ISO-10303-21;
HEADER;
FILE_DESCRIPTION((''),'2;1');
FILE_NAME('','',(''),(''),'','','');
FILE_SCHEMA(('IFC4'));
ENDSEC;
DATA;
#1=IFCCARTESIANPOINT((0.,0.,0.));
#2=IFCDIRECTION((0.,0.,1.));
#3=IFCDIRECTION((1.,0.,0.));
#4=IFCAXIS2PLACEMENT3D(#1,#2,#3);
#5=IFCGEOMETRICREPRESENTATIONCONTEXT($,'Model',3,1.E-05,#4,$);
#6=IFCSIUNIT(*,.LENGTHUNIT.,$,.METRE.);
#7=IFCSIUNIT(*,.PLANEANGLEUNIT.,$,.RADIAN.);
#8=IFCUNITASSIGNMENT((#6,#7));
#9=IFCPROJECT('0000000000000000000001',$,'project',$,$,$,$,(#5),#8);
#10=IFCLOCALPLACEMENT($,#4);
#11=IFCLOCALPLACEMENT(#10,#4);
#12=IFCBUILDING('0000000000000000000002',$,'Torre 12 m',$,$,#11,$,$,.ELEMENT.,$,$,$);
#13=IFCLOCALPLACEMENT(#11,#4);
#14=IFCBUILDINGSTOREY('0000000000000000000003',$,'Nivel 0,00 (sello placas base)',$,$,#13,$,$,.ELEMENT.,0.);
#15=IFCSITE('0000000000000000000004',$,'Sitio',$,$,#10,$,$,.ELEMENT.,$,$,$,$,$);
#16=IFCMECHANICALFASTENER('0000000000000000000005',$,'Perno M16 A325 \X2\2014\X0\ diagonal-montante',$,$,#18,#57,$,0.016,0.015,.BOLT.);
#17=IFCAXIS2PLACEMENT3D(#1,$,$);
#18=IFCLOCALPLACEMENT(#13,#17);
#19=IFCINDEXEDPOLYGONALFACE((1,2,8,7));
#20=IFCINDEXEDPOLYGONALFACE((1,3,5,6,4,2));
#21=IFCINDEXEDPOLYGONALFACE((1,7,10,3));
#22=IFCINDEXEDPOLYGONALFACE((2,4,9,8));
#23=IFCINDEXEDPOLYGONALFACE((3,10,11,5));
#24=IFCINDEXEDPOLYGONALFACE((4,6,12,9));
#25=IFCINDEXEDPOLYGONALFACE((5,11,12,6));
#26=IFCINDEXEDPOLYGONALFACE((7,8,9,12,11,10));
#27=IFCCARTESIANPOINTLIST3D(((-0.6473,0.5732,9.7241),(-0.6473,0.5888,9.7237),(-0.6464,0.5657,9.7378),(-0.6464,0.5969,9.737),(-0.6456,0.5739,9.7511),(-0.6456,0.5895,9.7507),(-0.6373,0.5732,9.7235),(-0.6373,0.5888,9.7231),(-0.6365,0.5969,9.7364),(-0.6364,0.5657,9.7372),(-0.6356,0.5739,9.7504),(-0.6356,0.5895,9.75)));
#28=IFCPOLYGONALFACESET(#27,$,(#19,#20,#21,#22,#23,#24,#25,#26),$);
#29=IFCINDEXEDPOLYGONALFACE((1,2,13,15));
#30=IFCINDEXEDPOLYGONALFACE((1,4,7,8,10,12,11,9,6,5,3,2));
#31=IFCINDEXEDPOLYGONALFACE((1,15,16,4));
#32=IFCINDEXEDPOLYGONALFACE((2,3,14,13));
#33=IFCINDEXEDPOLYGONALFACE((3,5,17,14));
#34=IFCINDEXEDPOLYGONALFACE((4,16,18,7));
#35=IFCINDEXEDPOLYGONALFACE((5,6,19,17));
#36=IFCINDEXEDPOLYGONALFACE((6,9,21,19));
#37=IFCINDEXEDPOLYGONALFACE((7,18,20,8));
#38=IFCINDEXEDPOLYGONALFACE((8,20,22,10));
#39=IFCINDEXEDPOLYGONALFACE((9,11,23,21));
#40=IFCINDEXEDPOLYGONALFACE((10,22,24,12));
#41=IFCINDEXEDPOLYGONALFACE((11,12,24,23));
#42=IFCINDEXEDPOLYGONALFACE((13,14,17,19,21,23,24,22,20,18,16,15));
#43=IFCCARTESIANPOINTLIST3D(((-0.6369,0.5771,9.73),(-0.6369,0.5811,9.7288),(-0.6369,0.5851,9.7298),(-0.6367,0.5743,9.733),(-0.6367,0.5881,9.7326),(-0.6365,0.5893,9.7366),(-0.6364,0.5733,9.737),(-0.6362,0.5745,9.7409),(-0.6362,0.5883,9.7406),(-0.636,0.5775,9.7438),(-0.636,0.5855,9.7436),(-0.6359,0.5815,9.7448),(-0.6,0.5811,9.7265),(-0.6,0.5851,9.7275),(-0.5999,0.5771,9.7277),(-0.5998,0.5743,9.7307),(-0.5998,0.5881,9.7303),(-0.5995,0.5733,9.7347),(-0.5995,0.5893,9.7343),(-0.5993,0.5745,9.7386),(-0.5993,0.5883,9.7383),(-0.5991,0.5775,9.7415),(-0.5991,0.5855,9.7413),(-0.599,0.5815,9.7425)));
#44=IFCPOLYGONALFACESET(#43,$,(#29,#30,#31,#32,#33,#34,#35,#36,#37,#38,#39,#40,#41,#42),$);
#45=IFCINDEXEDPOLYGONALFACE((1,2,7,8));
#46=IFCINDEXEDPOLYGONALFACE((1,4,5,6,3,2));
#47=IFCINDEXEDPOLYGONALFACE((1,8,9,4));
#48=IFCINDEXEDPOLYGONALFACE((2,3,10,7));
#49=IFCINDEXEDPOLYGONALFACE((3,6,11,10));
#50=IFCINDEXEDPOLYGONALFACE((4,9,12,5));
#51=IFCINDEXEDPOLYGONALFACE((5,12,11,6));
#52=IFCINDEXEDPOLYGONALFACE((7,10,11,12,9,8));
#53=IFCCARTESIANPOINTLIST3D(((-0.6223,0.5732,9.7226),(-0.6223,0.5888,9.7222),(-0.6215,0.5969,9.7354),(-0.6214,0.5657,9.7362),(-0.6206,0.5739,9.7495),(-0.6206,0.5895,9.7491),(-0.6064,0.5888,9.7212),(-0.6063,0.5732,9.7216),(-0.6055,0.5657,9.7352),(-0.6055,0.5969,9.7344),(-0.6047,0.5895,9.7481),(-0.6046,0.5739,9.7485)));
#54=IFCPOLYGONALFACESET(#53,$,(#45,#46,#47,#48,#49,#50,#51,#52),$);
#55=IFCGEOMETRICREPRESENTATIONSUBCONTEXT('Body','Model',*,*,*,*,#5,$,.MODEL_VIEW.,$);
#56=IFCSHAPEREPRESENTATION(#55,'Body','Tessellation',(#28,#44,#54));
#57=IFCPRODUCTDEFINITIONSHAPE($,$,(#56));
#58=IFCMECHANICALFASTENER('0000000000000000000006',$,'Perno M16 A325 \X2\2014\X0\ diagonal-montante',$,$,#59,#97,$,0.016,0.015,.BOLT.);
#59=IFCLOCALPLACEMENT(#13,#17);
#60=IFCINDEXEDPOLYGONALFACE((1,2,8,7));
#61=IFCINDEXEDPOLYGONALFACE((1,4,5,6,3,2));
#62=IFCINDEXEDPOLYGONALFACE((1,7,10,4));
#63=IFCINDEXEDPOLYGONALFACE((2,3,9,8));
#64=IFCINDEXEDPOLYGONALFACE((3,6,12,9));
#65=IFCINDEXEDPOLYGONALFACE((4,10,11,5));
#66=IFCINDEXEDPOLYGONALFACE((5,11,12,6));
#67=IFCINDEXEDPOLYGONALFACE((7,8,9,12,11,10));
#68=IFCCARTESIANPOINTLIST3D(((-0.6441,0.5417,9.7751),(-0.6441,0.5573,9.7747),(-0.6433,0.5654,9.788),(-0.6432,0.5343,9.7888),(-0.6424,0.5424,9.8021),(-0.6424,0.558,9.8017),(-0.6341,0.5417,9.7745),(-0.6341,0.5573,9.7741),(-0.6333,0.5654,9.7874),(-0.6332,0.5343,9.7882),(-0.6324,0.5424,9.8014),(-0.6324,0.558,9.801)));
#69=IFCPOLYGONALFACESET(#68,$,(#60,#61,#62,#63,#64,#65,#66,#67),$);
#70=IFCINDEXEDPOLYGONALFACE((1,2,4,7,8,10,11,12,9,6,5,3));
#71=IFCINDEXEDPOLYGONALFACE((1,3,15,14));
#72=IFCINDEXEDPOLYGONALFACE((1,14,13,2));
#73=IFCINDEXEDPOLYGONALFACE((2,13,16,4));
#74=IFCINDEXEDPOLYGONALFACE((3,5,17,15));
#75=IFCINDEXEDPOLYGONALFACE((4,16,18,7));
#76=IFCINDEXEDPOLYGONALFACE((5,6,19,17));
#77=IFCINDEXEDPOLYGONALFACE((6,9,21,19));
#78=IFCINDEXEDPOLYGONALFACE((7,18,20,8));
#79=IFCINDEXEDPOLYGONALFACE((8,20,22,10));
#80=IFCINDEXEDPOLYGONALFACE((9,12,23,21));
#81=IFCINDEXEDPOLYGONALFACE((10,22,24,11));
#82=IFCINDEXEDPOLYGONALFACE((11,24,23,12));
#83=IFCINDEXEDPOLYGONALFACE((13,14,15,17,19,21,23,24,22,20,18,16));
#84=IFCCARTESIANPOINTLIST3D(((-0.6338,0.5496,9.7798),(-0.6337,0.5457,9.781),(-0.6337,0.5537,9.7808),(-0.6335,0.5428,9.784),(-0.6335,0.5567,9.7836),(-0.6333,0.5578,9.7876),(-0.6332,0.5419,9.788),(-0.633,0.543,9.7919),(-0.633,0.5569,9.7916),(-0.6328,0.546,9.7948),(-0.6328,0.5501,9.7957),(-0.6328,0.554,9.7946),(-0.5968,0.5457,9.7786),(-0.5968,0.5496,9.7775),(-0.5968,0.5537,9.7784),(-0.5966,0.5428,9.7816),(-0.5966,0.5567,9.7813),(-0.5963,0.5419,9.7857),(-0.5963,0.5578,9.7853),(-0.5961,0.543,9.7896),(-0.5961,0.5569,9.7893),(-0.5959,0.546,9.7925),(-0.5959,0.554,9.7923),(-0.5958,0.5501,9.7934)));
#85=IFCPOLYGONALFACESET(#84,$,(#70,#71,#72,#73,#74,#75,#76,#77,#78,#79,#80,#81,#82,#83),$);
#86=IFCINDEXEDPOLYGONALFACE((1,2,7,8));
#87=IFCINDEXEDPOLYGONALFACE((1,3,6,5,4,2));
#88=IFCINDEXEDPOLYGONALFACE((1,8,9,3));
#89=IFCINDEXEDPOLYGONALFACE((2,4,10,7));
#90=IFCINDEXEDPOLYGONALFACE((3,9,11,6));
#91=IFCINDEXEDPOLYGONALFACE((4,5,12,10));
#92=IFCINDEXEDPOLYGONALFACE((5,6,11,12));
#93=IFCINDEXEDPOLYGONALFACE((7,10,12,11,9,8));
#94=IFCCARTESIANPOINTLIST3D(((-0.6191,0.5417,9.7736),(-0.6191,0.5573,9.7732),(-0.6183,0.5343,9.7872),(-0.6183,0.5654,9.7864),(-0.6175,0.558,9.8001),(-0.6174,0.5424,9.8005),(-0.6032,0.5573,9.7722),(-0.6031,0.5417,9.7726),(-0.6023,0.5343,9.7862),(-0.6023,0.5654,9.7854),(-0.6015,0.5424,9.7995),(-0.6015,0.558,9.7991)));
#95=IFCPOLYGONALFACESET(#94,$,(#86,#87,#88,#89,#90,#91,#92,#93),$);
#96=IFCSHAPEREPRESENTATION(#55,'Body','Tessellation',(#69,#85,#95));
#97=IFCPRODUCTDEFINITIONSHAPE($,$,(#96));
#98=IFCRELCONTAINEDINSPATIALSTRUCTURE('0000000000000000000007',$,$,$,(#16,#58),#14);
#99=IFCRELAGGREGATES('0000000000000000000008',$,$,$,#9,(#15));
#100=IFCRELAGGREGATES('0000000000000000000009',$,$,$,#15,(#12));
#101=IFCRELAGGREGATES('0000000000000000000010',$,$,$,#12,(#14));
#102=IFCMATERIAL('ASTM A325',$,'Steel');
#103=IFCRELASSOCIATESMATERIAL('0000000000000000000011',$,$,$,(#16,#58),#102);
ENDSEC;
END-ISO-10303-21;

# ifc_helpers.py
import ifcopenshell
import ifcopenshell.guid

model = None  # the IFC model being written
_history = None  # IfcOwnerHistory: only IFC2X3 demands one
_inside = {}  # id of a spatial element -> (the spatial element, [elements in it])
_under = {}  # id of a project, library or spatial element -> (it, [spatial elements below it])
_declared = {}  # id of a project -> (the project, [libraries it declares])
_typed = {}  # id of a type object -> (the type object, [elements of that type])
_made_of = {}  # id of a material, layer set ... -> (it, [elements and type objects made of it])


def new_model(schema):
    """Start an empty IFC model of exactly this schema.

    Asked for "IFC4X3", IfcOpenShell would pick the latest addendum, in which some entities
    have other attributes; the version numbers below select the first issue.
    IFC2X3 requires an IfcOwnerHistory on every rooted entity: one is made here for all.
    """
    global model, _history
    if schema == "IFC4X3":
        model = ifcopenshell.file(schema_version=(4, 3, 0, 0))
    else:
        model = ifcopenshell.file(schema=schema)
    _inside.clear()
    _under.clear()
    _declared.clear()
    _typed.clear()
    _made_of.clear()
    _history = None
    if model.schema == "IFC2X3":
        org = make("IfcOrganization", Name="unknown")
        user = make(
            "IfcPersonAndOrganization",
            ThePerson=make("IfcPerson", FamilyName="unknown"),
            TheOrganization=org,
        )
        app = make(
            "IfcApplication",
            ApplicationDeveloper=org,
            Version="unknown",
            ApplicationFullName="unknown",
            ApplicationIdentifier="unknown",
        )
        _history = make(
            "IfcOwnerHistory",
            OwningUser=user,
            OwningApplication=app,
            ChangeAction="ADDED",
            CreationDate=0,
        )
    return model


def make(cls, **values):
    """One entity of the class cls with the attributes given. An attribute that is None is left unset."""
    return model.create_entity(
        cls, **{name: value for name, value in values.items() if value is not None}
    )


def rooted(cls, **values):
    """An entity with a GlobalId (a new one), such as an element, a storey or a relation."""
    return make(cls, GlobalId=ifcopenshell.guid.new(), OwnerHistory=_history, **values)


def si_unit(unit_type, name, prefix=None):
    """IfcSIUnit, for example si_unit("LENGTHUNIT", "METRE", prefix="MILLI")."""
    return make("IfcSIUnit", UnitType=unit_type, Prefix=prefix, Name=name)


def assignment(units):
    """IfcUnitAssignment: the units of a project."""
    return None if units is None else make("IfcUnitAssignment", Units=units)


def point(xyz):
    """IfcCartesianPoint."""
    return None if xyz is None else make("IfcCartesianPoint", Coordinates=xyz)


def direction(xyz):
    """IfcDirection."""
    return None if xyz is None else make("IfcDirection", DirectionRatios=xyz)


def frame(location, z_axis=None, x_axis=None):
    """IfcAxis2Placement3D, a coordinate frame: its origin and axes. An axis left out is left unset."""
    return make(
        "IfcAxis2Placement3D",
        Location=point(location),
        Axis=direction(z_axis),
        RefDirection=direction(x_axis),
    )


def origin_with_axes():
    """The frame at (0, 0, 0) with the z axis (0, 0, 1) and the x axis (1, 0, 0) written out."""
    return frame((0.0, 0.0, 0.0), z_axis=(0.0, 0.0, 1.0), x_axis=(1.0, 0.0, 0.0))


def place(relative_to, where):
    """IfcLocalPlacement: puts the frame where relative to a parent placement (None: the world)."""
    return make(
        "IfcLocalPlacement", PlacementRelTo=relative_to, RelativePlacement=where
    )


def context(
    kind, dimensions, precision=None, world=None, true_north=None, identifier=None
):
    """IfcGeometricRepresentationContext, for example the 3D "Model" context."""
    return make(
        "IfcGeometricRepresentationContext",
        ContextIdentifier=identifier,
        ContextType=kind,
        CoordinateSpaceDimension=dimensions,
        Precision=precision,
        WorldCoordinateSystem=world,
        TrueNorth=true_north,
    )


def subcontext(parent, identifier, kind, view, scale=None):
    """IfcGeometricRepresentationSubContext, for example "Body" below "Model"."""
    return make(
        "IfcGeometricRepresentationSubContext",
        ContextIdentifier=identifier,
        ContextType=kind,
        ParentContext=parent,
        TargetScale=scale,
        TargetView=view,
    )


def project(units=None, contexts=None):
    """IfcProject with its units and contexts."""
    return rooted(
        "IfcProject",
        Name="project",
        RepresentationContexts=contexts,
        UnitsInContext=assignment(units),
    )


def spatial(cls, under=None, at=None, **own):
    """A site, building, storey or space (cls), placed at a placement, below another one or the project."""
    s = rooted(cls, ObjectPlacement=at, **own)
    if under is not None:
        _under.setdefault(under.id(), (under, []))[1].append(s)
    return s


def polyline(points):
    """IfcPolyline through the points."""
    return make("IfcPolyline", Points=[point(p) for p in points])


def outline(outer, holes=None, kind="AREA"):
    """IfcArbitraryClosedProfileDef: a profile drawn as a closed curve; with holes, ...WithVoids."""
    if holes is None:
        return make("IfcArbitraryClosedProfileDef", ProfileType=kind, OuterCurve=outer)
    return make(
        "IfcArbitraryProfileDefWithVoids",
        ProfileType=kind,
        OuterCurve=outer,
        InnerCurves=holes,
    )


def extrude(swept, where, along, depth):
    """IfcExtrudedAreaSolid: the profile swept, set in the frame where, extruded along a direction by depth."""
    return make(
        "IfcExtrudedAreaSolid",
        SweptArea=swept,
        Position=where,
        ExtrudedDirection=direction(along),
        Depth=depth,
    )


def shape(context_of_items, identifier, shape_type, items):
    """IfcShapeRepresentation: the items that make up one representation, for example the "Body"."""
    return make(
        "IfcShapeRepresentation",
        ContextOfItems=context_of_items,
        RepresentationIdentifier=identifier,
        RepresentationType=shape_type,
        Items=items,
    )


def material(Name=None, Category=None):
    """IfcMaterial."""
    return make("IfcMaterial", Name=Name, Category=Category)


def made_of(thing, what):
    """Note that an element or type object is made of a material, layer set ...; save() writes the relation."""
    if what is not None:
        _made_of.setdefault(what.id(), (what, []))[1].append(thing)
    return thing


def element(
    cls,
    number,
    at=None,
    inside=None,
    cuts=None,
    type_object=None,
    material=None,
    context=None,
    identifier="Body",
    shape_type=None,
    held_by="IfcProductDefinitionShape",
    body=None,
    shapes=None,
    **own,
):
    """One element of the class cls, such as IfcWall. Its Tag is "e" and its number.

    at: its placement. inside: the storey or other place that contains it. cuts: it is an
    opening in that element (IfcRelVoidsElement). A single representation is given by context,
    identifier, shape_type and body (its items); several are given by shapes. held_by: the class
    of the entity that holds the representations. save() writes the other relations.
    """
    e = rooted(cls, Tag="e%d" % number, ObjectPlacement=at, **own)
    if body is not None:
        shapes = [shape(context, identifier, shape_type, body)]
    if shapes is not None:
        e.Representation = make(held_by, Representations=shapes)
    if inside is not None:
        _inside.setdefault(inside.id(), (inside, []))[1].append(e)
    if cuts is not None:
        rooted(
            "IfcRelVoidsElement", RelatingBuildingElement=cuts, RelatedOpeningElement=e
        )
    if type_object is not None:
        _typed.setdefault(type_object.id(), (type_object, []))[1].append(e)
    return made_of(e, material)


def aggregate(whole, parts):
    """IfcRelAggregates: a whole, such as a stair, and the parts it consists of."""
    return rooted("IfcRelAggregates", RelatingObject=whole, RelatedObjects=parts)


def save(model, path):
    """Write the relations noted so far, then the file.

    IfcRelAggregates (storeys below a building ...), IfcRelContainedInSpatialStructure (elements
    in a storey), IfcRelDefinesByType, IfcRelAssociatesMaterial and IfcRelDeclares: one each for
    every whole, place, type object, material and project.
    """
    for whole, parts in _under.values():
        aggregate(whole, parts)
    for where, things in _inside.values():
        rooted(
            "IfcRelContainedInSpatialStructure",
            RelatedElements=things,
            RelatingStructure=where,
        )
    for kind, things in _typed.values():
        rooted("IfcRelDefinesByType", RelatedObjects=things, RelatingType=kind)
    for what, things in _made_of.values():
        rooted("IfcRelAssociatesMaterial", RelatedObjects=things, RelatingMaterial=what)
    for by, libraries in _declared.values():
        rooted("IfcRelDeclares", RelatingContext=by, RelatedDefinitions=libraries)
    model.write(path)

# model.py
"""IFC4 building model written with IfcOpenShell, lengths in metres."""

from ifc_helpers import new_model, si_unit, frame, origin_with_axes, place, context, subcontext, project, spatial, polyline, outline, extrude, material, element, save


model = new_model("IFC4")

# Units and contexts
model_context = context("Model", 3, precision=1e-05, world=origin_with_axes())
body_context = subcontext(model_context, "Body", "Model", "MODEL_VIEW")
ifc_project = project(units=[si_unit("LENGTHUNIT", "METRE"), si_unit("PLANEANGLEUNIT", "RADIAN")], contexts=[model_context])

# Site, building, storey
site_placement = place(None, origin_with_axes())
site = spatial("IfcSite", under=ifc_project, at=site_placement, Name="Sitio", CompositionType="ELEMENT")
building_placement = place(site_placement, origin_with_axes())
building = spatial("IfcBuilding", under=site, at=building_placement, Name="Torre 12 m", CompositionType="ELEMENT")
storey_placement = place(building_placement, origin_with_axes())
storey = spatial("IfcBuildingStorey", under=building, at=storey_placement, Name="Nivel 0,00 (sello placas base)", CompositionType="ELEMENT", Elevation=0.0)

# Shared definitions
placement = place(storey_placement, origin_with_axes())

# Mechanical fasteners
ifc_material_1 = material(Name="ASTM A325", Category="Steel")
element("IfcMechanicalFastener", 1, at=placement, inside=storey, material=ifc_material_1, Name="Perno M16 A325 — diagonal-montante", NominalDiameter=0.016, NominalLength=0.015, PredefinedType="BOLT", context=body_context, shape_type="SweptSolid", body=[
    extrude(outline(polyline([(0.0135, 0.0078), (0.0, 0.0156), (-0.0135, 0.0078), (-0.0135, -0.0078), (0.0, -0.0156), (0.0135, -0.0078), (0.0135, 0.0078)])), frame((-0.6464, 0.5813, 9.7374), z_axis=(0.998053, 0.0, -0.062378), x_axis=(0.032557, -0.85299, 0.52091)), (0.0, 0.0, 1.0), 0.01),
    extrude(outline(polyline([(0.008, 0.0), (0.0069, 0.004), (0.004, 0.0069), (0.0, 0.008), (-0.004, 0.0069), (-0.0069, 0.004), (-0.008, 0.0), (-0.0069, -0.004), (-0.004, -0.0069), (0.0, -0.008), (0.004, -0.0069), (0.0069, -0.004), (0.008, 0.0)])), frame((-0.6364, 0.5813, 9.7368), z_axis=(0.998053, 0.0, -0.062378), x_axis=(0.032557, -0.85299, 0.52091)), (0.0, 0.0, 1.0), 0.037),
    extrude(outline(polyline([(0.0135, 0.0078), (0.0, 0.0156), (-0.0135, 0.0078), (-0.0135, -0.0078), (0.0, -0.0156), (0.0135, -0.0078), (0.0135, 0.0078)])), frame((-0.6215, 0.5813, 9.7358), z_axis=(0.998053, 0.0, -0.062378), x_axis=(0.032557, -0.85299, 0.52091)), (0.0, 0.0, 1.0), 0.016),
])
element("IfcMechanicalFastener", 2, at=placement, inside=storey, material=ifc_material_1, Name="Perno M16 A325 — diagonal-montante", NominalDiameter=0.016, NominalLength=0.015, PredefinedType="BOLT", context=body_context, shape_type="SweptSolid", body=[
    extrude(outline(polyline([(0.0135, 0.0078), (0.0, 0.0156), (-0.0135, 0.0078), (-0.0135, -0.0078), (0.0, -0.0156), (0.0135, -0.0078), (0.0135, 0.0078)])), frame((-0.6432, 0.5499, 9.7884), z_axis=(0.998053, 0.0, -0.062378), x_axis=(0.032557, -0.85299, 0.52091)), (0.0, 0.0, 1.0), 0.01),
    extrude(outline(polyline([(0.008, 0.0), (0.0069, 0.004), (0.004, 0.0069), (0.0, 0.008), (-0.004, 0.0069), (-0.0069, 0.004), (-0.008, 0.0), (-0.0069, -0.004), (-0.004, -0.0069), (0.0, -0.008), (0.004, -0.0069), (0.0069, -0.004), (0.008, 0.0)])), frame((-0.6333, 0.5499, 9.7878), z_axis=(0.998053, 0.0, -0.062378), x_axis=(0.032557, -0.85299, 0.52091)), (0.0, 0.0, 1.0), 0.037),
    extrude(outline(polyline([(0.0135, 0.0078), (0.0, 0.0156), (-0.0135, 0.0078), (-0.0135, -0.0078), (0.0, -0.0156), (0.0135, -0.0078), (0.0135, 0.0078)])), frame((-0.6183, 0.5499, 9.7868), z_axis=(0.998053, 0.0, -0.062378), x_axis=(0.032557, -0.85299, 0.52091)), (0.0, 0.0, 1.0), 0.016),
])

save(model, "model.ifc")
